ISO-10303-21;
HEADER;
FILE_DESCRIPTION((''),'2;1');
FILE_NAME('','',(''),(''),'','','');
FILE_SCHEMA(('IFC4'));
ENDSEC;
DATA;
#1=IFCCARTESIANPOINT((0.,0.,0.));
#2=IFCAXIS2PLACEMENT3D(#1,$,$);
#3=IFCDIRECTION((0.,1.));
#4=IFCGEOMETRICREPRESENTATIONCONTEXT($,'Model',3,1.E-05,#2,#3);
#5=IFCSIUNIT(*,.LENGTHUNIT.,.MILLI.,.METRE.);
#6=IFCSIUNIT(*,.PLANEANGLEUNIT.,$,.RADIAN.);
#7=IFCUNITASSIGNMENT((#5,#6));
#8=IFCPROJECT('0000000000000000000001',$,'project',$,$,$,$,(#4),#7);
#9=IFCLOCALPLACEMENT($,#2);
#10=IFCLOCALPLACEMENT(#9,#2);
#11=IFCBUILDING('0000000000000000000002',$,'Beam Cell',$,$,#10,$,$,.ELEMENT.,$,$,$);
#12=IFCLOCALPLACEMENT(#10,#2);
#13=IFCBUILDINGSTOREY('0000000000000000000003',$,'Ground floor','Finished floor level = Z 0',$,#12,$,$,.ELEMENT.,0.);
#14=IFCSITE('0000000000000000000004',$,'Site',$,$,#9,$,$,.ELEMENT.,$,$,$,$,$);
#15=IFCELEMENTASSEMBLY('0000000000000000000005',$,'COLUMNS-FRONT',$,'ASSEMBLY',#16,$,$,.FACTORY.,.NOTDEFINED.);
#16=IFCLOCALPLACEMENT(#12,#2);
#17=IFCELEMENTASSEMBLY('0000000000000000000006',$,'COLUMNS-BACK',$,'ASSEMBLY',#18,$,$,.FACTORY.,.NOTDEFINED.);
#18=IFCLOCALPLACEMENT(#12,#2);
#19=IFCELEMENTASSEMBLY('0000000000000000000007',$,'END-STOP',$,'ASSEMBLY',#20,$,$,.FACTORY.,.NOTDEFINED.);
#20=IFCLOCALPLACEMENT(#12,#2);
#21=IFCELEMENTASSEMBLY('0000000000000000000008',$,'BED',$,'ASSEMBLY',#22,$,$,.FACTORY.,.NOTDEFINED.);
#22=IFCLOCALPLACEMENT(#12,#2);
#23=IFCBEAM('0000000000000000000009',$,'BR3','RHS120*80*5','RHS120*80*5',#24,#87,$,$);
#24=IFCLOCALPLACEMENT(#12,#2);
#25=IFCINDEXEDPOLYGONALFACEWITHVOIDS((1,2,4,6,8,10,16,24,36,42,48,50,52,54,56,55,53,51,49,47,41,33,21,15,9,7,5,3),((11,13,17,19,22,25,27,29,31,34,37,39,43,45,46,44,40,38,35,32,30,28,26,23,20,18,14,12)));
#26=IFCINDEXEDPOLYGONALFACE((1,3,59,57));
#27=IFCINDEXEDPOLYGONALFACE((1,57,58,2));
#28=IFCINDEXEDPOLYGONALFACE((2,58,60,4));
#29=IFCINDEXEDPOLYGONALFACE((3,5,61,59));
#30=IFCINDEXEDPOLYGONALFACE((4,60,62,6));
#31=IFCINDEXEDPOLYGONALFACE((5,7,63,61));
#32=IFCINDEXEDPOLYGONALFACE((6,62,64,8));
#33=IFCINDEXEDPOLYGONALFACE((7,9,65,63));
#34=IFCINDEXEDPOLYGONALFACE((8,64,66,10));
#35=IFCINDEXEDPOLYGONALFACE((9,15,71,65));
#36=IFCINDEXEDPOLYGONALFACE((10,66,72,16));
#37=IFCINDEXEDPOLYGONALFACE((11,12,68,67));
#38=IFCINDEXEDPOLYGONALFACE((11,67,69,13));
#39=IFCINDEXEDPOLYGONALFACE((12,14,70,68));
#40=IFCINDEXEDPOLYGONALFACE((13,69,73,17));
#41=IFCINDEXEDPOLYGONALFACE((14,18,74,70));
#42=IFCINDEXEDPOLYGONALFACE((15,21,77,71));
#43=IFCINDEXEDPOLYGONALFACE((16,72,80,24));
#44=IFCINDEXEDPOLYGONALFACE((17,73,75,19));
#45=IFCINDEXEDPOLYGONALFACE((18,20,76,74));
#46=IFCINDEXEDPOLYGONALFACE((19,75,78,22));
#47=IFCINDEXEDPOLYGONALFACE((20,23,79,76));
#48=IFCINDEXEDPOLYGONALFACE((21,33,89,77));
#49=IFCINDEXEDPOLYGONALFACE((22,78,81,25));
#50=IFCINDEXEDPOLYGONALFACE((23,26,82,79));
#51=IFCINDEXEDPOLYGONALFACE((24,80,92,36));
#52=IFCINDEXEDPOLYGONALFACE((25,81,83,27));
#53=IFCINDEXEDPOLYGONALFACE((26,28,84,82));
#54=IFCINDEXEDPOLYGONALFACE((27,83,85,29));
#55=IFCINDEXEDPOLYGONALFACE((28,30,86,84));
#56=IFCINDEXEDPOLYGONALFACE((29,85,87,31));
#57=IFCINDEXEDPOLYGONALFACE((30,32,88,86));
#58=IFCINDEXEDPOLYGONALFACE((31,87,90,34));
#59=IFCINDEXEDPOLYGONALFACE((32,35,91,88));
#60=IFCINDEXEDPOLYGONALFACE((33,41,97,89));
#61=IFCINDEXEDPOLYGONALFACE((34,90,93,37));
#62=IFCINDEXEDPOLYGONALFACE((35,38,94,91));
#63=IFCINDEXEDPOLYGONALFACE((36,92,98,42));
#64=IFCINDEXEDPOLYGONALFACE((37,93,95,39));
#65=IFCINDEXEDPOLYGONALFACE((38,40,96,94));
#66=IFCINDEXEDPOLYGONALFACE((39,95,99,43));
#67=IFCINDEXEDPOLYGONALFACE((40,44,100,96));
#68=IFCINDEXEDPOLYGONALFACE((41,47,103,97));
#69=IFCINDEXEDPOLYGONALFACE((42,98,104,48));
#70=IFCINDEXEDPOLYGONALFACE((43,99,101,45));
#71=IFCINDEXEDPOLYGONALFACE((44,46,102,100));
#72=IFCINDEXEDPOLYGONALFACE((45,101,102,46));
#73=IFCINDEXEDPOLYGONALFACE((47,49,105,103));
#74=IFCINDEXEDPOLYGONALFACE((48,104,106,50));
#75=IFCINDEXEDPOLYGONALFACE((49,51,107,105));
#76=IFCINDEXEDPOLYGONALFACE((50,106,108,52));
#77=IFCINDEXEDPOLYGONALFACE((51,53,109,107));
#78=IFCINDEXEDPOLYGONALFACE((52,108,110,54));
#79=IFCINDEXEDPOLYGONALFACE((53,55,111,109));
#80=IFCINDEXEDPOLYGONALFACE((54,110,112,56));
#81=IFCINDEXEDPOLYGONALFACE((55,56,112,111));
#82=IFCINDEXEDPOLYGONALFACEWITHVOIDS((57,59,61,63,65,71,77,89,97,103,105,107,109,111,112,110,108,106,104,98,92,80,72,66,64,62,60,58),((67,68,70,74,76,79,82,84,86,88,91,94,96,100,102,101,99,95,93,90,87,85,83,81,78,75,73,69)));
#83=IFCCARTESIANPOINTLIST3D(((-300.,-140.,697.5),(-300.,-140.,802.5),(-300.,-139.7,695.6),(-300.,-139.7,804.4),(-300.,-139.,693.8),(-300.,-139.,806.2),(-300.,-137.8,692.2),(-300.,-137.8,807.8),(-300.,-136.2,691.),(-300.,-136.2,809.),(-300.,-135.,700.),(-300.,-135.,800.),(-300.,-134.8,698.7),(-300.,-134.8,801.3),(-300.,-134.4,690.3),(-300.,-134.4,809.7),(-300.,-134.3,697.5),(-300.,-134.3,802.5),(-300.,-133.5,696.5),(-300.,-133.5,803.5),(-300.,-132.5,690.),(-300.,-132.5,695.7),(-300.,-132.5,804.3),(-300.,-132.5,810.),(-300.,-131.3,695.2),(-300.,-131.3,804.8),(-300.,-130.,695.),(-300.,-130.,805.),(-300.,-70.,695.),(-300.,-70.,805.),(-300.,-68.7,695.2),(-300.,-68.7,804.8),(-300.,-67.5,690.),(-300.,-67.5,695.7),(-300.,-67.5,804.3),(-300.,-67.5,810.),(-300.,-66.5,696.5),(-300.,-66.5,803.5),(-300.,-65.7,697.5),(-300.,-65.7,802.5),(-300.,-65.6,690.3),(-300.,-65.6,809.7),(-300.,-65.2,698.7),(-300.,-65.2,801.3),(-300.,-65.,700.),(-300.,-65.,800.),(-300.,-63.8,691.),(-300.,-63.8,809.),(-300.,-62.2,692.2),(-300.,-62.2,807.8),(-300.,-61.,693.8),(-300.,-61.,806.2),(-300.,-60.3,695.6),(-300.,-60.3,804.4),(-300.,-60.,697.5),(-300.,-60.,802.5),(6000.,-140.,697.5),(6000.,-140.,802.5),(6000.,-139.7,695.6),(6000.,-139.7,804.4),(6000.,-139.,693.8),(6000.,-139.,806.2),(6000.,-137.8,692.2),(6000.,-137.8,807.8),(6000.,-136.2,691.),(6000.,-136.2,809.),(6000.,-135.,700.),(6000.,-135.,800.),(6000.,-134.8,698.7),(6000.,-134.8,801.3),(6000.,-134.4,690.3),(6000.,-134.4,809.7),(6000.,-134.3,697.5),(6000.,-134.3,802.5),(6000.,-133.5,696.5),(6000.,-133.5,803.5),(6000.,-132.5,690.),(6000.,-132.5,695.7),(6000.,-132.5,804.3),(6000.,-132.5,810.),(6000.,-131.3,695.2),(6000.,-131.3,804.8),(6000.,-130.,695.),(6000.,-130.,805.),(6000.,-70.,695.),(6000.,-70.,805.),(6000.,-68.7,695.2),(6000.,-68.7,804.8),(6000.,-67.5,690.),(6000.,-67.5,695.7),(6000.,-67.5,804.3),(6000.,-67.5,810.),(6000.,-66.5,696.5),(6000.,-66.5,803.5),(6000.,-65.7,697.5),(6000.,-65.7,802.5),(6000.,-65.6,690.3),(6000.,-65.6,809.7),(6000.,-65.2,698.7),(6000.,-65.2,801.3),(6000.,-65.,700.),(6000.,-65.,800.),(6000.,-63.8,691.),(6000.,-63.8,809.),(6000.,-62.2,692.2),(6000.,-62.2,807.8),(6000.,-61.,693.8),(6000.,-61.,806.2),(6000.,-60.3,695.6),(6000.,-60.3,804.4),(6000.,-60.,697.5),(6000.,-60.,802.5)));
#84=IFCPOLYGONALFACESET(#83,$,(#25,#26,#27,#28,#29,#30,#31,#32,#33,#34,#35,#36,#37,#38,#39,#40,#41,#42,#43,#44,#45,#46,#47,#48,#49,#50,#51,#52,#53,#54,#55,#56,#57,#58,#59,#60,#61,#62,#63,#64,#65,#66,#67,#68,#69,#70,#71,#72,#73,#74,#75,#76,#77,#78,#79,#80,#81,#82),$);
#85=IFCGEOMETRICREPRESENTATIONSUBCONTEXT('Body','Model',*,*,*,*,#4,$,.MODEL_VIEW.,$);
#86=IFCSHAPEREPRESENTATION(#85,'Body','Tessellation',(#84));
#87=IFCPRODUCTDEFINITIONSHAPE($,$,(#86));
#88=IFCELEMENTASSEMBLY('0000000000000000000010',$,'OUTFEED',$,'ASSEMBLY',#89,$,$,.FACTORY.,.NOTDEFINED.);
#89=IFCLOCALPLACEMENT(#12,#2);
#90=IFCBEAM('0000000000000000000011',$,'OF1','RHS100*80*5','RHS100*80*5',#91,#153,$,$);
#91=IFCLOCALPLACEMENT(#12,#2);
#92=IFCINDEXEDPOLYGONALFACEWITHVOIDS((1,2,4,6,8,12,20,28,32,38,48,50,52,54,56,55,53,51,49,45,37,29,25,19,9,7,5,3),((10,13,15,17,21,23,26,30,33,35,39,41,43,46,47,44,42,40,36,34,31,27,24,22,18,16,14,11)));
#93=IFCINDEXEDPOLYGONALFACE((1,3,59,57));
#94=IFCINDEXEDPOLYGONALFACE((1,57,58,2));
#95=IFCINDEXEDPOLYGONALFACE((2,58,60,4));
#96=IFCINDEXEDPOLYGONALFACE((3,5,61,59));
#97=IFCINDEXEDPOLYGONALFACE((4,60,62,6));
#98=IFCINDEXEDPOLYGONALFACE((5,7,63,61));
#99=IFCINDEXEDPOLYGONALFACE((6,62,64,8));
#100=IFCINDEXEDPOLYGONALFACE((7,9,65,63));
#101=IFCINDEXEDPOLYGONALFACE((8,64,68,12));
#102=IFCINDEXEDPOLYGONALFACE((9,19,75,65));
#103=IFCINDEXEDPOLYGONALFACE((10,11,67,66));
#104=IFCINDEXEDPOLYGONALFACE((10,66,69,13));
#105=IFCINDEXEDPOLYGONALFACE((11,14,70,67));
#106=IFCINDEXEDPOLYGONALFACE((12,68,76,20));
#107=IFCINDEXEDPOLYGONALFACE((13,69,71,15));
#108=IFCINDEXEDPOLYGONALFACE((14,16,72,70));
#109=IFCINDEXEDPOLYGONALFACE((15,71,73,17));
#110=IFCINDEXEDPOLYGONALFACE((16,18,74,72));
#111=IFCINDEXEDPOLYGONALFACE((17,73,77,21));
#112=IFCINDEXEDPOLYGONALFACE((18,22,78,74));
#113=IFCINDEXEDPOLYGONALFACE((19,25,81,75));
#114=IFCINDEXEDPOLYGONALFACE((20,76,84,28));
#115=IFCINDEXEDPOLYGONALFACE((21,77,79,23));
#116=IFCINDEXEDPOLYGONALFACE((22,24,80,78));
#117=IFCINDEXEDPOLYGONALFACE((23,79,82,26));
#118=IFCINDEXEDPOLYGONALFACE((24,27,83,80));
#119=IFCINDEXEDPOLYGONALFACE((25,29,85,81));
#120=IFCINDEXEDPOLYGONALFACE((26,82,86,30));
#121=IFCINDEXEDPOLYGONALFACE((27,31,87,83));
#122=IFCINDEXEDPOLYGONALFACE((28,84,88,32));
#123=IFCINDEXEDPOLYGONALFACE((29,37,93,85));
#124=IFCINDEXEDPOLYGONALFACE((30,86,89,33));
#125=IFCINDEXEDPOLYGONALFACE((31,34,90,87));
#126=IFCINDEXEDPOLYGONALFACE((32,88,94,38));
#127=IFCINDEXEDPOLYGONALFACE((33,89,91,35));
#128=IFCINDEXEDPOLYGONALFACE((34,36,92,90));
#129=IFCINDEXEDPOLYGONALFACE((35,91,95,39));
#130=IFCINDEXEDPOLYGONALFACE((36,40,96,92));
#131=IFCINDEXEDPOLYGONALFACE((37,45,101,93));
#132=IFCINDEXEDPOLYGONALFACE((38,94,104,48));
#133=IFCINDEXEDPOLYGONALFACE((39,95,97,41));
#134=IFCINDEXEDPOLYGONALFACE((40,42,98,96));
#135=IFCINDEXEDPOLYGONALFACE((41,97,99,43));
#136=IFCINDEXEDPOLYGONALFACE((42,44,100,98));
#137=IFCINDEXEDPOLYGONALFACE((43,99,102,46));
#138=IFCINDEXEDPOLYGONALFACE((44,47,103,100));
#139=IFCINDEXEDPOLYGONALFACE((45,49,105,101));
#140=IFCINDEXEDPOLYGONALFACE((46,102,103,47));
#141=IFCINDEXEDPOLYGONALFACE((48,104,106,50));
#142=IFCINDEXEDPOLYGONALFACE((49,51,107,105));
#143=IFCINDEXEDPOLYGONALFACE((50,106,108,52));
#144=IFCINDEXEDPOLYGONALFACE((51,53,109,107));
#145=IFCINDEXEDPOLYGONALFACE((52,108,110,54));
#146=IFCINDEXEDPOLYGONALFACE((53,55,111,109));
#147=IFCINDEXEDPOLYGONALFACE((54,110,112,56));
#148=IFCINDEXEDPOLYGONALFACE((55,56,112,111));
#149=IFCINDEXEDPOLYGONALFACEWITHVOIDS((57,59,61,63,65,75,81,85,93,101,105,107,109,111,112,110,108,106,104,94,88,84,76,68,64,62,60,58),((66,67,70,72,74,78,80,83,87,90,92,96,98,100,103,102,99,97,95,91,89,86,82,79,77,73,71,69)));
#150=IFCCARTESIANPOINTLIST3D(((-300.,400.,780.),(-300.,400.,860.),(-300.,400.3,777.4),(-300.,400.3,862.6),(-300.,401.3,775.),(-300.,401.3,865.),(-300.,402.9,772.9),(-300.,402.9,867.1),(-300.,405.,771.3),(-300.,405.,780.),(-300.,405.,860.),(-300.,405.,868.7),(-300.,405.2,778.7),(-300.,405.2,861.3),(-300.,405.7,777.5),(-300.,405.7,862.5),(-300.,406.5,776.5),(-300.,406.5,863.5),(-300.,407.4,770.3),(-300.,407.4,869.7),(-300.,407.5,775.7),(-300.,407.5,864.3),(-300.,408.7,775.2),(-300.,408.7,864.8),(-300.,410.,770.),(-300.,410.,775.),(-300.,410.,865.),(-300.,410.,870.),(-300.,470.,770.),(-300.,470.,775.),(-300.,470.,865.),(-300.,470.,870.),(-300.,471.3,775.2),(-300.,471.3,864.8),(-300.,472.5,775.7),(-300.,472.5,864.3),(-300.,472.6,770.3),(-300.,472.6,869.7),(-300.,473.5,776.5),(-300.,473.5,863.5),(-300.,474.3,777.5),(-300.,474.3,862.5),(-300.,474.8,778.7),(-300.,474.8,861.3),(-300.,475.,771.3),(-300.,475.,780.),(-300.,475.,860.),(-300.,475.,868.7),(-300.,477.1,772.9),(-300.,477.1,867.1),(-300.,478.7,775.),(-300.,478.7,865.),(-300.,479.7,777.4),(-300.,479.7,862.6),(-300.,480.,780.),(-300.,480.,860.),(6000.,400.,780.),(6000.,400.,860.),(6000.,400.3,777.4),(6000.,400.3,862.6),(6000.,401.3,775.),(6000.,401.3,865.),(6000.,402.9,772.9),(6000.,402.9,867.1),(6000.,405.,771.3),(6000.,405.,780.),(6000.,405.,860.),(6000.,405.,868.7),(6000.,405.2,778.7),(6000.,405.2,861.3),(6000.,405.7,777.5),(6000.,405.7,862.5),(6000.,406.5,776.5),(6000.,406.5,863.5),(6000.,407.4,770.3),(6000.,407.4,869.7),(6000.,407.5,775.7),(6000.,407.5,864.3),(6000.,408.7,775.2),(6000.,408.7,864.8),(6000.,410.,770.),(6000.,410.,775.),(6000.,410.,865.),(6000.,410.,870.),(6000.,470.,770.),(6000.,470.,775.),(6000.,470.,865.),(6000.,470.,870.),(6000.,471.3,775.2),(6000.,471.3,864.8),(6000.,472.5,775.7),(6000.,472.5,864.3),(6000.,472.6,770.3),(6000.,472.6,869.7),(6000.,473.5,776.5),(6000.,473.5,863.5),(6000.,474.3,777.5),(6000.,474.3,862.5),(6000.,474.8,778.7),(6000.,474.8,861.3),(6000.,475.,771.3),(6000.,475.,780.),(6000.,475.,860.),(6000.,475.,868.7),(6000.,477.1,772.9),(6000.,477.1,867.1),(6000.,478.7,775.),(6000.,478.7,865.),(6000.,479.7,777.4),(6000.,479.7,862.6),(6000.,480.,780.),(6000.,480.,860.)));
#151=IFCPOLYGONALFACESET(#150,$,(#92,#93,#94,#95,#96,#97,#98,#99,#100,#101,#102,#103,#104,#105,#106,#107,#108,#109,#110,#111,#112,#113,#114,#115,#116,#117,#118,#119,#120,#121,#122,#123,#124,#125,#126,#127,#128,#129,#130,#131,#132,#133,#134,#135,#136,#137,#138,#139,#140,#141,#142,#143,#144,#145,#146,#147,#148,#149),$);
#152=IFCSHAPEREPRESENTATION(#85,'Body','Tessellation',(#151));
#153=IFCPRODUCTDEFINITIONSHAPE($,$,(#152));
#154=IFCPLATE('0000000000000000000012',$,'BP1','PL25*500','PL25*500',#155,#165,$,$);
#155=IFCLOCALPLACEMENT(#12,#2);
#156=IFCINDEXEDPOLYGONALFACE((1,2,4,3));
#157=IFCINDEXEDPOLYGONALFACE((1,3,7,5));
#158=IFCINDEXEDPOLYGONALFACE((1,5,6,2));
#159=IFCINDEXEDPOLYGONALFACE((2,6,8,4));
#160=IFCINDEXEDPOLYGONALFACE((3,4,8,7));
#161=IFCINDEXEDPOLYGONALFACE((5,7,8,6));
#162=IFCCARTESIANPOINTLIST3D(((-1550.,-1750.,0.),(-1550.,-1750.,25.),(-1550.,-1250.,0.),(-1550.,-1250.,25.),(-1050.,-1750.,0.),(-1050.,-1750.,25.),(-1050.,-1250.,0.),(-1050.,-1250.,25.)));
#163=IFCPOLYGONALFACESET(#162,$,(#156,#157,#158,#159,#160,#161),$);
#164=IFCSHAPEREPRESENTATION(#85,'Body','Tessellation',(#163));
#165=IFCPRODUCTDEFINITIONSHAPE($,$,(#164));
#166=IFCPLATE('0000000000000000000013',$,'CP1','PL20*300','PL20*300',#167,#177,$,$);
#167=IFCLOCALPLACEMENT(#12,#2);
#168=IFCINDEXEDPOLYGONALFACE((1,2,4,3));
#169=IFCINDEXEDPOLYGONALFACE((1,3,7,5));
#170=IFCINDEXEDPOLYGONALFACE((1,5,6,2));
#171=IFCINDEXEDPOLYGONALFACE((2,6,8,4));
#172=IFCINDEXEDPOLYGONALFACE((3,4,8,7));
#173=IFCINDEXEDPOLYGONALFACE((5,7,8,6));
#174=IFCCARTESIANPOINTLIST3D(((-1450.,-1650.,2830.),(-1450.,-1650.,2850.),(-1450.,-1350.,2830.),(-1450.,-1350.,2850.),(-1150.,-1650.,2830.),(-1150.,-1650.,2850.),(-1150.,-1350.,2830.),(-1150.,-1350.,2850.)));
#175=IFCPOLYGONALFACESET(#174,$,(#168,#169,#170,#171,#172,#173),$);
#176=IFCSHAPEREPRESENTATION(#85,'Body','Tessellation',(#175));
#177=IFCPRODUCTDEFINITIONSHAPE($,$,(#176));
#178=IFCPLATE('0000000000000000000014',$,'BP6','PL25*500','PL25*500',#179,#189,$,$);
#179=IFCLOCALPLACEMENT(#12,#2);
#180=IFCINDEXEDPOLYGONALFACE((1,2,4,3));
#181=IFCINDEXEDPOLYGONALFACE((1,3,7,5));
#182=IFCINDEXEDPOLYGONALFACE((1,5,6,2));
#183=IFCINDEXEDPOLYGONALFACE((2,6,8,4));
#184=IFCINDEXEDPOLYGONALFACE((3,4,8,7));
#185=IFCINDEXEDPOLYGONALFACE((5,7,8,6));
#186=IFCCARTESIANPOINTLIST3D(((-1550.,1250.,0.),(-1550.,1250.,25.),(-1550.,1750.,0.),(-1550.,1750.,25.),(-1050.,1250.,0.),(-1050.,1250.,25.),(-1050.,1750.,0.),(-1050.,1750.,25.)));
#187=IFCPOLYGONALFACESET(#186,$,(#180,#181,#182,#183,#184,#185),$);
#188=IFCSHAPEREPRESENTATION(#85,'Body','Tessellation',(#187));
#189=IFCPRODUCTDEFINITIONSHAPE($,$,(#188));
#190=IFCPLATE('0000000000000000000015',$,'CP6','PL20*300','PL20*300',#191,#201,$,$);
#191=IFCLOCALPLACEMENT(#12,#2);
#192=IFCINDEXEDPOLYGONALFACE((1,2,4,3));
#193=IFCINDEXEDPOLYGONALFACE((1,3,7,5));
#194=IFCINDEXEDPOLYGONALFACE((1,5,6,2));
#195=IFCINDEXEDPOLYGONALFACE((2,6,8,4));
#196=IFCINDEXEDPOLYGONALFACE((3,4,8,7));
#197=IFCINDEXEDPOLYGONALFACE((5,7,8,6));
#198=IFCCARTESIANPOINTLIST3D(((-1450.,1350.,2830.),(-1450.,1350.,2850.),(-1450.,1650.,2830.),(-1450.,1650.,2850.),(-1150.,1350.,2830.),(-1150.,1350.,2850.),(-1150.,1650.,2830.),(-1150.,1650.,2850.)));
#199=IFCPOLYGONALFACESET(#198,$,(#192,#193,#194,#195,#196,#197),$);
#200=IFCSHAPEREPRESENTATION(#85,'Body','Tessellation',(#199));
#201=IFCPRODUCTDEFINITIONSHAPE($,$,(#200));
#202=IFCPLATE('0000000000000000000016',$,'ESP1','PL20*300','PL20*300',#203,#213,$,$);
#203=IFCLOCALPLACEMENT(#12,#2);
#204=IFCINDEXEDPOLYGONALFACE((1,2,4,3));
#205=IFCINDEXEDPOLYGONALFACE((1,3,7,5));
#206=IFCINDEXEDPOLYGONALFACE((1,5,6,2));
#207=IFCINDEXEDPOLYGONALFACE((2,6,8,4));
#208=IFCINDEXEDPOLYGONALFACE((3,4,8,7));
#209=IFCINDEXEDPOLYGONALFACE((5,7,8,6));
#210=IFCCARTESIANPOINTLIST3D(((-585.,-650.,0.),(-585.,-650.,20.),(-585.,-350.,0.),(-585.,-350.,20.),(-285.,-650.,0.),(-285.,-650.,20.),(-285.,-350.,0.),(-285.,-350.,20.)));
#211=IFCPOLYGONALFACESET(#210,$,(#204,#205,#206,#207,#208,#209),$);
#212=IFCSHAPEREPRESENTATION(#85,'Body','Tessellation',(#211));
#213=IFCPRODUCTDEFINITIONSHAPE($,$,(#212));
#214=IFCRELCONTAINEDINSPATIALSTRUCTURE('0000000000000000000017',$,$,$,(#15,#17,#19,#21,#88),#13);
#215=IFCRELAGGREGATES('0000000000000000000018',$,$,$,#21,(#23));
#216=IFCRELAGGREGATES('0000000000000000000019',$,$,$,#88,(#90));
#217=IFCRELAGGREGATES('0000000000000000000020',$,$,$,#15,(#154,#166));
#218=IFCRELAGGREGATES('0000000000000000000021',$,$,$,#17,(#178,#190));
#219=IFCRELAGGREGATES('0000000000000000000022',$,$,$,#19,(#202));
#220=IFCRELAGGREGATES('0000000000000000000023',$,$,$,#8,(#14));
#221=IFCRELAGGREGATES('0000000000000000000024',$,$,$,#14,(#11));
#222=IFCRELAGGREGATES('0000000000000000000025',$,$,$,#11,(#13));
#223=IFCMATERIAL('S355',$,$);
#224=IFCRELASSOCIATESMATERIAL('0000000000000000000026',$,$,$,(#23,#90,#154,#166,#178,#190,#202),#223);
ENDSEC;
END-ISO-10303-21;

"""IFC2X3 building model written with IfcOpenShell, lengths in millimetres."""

from ifc_helpers import new_model, si_unit, direction, frame, origin, origin_2d, place, context, subcontext, project, spatial, rectangle, hollow_rectangle, extrude, material, element, aggregate, save


model = new_model("IFC2X3")

# Units and contexts
model_context = context("Model", 3, precision=1e-05, world=origin(), true_north=direction((0.0, 1.0)))
body_context = subcontext(model_context, "Body", "Model", "MODEL_VIEW")
ifc_project = project(units=[si_unit("LENGTHUNIT", "METRE", prefix="MILLI"), si_unit("PLANEANGLEUNIT", "RADIAN")], contexts=[model_context])

# Site, building, storey
site_placement = place(None, origin())
site = spatial("IfcSite", under=ifc_project, at=site_placement, Name="Site", CompositionType="ELEMENT")
building_placement = place(site_placement, origin())
building = spatial("IfcBuilding", under=site, at=building_placement, Name="Beam Cell", CompositionType="ELEMENT")
storey_placement = place(building_placement, origin())
storey = spatial("IfcBuildingStorey", under=building, at=storey_placement, Name="Ground floor", Description="Finished floor level = Z 0", CompositionType="ELEMENT", Elevation=0.0)

# Element assemblies
assembly_1_placement = place(storey_placement, origin())
assembly_1 = element("IfcElementAssembly", 1, at=assembly_1_placement, inside=storey, Name="COLUMNS-FRONT", ObjectType="ASSEMBLY", AssemblyPlace="FACTORY", PredefinedType="NOTDEFINED")
ifc_material = material(Name="S355")
assembly_2_placement = place(storey_placement, origin())
assembly_2 = element("IfcElementAssembly", 2, at=assembly_2_placement, inside=storey, Name="COLUMNS-BACK", ObjectType="ASSEMBLY", AssemblyPlace="FACTORY", PredefinedType="NOTDEFINED")
assembly_3_placement = place(storey_placement, origin())
assembly_3 = element("IfcElementAssembly", 3, at=assembly_3_placement, inside=storey, Name="END-STOP", ObjectType="ASSEMBLY", AssemblyPlace="FACTORY", PredefinedType="NOTDEFINED")

# Element assembly, beam
assembly_4_placement = place(storey_placement, origin())
assembly_4 = element("IfcElementAssembly", 4, at=assembly_4_placement, inside=storey, Name="BED", ObjectType="ASSEMBLY", AssemblyPlace="FACTORY", PredefinedType="NOTDEFINED")
beam_1_placement = place(storey_placement, frame((-300.0, -100.0, 750.0), z_axis=(1.0, 0.0, 0.0), x_axis=(0.0, 1.0, 0.0)))
beam_1 = element("IfcBeam", 5, at=beam_1_placement, material=ifc_material, Name="BR3", Description="RHS120*80*5", ObjectType="RHS120*80*5", context=body_context, shape_type="SweptSolid", body=[
    extrude(hollow_rectangle(XDim=80.0, YDim=120.0, WallThickness=5.0, InnerFilletRadius=5.0, OuterFilletRadius=7.5, at=origin_2d()), origin(), (0.0, 0.0, 1.0), 6300.0),
])
aggregate(assembly_4, [beam_1])

# Element assembly, beam
assembly_5_placement = place(storey_placement, origin())
assembly_5 = element("IfcElementAssembly", 6, at=assembly_5_placement, inside=storey, Name="OUTFEED", ObjectType="ASSEMBLY", AssemblyPlace="FACTORY", PredefinedType="NOTDEFINED")
beam_2_placement = place(storey_placement, frame((-300.0, 440.0, 820.0), z_axis=(1.0, 0.0, 0.0), x_axis=(0.0, 1.0, 0.0)))
beam_2 = element("IfcBeam", 7, at=beam_2_placement, material=ifc_material, Name="OF1", Description="RHS100*80*5", ObjectType="RHS100*80*5", context=body_context, shape_type="SweptSolid", body=[
    extrude(hollow_rectangle(XDim=80.0, YDim=100.0, WallThickness=5.0, InnerFilletRadius=5.0, OuterFilletRadius=10.0, at=origin_2d()), origin(), (0.0, 0.0, 1.0), 6300.0),
])
aggregate(assembly_5, [beam_2])

# Plates
plate_1_placement = place(storey_placement, frame((-1300.0, -1500.0, 0.0), z_axis=(0.0, 0.0, 1.0), x_axis=(1.0, 0.0, 0.0)))
plate_1 = element("IfcPlate", 8, at=plate_1_placement, material=ifc_material, Name="BP1", Description="PL25*500", ObjectType="PL25*500", context=body_context, shape_type="SweptSolid", body=[
    extrude(rectangle(XDim=500.0, YDim=500.0, at=origin_2d()), origin(), (0.0, 0.0, 1.0), 25.0),
])
plate_2_placement = place(storey_placement, frame((-1300.0, -1500.0, 2830.0), z_axis=(0.0, 0.0, 1.0), x_axis=(1.0, 0.0, 0.0)))
plate_2 = element("IfcPlate", 9, at=plate_2_placement, material=ifc_material, Name="CP1", Description="PL20*300", ObjectType="PL20*300", context=body_context, shape_type="SweptSolid", body=[
    extrude(rectangle(XDim=300.0, YDim=300.0, at=origin_2d()), origin(), (0.0, 0.0, 1.0), 20.0),
])
aggregate(assembly_1, [plate_1, plate_2])
plate_3_placement = place(storey_placement, frame((-1300.0, 1500.0, 0.0), z_axis=(0.0, 0.0, 1.0), x_axis=(1.0, 0.0, 0.0)))
plate_3 = element("IfcPlate", 10, at=plate_3_placement, material=ifc_material, Name="BP6", Description="PL25*500", ObjectType="PL25*500", context=body_context, shape_type="SweptSolid", body=[
    extrude(rectangle(XDim=500.0, YDim=500.0, at=origin_2d()), origin(), (0.0, 0.0, 1.0), 25.0),
])
plate_4_placement = place(storey_placement, frame((-1300.0, 1500.0, 2830.0), z_axis=(0.0, 0.0, 1.0), x_axis=(1.0, 0.0, 0.0)))
plate_4 = element("IfcPlate", 11, at=plate_4_placement, material=ifc_material, Name="CP6", Description="PL20*300", ObjectType="PL20*300", context=body_context, shape_type="SweptSolid", body=[
    extrude(rectangle(XDim=300.0, YDim=300.0, at=origin_2d()), origin(), (0.0, 0.0, 1.0), 20.0),
])
aggregate(assembly_2, [plate_3, plate_4])
plate_5_placement = place(storey_placement, frame((-435.0, -500.0, 0.0), z_axis=(0.0, 0.0, 1.0), x_axis=(1.0, 0.0, 0.0)))
plate_5 = element("IfcPlate", 12, at=plate_5_placement, material=ifc_material, Name="ESP1", Description="PL20*300", ObjectType="PL20*300", context=body_context, shape_type="SweptSolid", body=[
    extrude(rectangle(XDim=300.0, YDim=300.0, at=origin_2d()), origin(), (0.0, 0.0, 1.0), 20.0),
])
aggregate(assembly_3, [plate_5])

save(model, "model.ifc")
